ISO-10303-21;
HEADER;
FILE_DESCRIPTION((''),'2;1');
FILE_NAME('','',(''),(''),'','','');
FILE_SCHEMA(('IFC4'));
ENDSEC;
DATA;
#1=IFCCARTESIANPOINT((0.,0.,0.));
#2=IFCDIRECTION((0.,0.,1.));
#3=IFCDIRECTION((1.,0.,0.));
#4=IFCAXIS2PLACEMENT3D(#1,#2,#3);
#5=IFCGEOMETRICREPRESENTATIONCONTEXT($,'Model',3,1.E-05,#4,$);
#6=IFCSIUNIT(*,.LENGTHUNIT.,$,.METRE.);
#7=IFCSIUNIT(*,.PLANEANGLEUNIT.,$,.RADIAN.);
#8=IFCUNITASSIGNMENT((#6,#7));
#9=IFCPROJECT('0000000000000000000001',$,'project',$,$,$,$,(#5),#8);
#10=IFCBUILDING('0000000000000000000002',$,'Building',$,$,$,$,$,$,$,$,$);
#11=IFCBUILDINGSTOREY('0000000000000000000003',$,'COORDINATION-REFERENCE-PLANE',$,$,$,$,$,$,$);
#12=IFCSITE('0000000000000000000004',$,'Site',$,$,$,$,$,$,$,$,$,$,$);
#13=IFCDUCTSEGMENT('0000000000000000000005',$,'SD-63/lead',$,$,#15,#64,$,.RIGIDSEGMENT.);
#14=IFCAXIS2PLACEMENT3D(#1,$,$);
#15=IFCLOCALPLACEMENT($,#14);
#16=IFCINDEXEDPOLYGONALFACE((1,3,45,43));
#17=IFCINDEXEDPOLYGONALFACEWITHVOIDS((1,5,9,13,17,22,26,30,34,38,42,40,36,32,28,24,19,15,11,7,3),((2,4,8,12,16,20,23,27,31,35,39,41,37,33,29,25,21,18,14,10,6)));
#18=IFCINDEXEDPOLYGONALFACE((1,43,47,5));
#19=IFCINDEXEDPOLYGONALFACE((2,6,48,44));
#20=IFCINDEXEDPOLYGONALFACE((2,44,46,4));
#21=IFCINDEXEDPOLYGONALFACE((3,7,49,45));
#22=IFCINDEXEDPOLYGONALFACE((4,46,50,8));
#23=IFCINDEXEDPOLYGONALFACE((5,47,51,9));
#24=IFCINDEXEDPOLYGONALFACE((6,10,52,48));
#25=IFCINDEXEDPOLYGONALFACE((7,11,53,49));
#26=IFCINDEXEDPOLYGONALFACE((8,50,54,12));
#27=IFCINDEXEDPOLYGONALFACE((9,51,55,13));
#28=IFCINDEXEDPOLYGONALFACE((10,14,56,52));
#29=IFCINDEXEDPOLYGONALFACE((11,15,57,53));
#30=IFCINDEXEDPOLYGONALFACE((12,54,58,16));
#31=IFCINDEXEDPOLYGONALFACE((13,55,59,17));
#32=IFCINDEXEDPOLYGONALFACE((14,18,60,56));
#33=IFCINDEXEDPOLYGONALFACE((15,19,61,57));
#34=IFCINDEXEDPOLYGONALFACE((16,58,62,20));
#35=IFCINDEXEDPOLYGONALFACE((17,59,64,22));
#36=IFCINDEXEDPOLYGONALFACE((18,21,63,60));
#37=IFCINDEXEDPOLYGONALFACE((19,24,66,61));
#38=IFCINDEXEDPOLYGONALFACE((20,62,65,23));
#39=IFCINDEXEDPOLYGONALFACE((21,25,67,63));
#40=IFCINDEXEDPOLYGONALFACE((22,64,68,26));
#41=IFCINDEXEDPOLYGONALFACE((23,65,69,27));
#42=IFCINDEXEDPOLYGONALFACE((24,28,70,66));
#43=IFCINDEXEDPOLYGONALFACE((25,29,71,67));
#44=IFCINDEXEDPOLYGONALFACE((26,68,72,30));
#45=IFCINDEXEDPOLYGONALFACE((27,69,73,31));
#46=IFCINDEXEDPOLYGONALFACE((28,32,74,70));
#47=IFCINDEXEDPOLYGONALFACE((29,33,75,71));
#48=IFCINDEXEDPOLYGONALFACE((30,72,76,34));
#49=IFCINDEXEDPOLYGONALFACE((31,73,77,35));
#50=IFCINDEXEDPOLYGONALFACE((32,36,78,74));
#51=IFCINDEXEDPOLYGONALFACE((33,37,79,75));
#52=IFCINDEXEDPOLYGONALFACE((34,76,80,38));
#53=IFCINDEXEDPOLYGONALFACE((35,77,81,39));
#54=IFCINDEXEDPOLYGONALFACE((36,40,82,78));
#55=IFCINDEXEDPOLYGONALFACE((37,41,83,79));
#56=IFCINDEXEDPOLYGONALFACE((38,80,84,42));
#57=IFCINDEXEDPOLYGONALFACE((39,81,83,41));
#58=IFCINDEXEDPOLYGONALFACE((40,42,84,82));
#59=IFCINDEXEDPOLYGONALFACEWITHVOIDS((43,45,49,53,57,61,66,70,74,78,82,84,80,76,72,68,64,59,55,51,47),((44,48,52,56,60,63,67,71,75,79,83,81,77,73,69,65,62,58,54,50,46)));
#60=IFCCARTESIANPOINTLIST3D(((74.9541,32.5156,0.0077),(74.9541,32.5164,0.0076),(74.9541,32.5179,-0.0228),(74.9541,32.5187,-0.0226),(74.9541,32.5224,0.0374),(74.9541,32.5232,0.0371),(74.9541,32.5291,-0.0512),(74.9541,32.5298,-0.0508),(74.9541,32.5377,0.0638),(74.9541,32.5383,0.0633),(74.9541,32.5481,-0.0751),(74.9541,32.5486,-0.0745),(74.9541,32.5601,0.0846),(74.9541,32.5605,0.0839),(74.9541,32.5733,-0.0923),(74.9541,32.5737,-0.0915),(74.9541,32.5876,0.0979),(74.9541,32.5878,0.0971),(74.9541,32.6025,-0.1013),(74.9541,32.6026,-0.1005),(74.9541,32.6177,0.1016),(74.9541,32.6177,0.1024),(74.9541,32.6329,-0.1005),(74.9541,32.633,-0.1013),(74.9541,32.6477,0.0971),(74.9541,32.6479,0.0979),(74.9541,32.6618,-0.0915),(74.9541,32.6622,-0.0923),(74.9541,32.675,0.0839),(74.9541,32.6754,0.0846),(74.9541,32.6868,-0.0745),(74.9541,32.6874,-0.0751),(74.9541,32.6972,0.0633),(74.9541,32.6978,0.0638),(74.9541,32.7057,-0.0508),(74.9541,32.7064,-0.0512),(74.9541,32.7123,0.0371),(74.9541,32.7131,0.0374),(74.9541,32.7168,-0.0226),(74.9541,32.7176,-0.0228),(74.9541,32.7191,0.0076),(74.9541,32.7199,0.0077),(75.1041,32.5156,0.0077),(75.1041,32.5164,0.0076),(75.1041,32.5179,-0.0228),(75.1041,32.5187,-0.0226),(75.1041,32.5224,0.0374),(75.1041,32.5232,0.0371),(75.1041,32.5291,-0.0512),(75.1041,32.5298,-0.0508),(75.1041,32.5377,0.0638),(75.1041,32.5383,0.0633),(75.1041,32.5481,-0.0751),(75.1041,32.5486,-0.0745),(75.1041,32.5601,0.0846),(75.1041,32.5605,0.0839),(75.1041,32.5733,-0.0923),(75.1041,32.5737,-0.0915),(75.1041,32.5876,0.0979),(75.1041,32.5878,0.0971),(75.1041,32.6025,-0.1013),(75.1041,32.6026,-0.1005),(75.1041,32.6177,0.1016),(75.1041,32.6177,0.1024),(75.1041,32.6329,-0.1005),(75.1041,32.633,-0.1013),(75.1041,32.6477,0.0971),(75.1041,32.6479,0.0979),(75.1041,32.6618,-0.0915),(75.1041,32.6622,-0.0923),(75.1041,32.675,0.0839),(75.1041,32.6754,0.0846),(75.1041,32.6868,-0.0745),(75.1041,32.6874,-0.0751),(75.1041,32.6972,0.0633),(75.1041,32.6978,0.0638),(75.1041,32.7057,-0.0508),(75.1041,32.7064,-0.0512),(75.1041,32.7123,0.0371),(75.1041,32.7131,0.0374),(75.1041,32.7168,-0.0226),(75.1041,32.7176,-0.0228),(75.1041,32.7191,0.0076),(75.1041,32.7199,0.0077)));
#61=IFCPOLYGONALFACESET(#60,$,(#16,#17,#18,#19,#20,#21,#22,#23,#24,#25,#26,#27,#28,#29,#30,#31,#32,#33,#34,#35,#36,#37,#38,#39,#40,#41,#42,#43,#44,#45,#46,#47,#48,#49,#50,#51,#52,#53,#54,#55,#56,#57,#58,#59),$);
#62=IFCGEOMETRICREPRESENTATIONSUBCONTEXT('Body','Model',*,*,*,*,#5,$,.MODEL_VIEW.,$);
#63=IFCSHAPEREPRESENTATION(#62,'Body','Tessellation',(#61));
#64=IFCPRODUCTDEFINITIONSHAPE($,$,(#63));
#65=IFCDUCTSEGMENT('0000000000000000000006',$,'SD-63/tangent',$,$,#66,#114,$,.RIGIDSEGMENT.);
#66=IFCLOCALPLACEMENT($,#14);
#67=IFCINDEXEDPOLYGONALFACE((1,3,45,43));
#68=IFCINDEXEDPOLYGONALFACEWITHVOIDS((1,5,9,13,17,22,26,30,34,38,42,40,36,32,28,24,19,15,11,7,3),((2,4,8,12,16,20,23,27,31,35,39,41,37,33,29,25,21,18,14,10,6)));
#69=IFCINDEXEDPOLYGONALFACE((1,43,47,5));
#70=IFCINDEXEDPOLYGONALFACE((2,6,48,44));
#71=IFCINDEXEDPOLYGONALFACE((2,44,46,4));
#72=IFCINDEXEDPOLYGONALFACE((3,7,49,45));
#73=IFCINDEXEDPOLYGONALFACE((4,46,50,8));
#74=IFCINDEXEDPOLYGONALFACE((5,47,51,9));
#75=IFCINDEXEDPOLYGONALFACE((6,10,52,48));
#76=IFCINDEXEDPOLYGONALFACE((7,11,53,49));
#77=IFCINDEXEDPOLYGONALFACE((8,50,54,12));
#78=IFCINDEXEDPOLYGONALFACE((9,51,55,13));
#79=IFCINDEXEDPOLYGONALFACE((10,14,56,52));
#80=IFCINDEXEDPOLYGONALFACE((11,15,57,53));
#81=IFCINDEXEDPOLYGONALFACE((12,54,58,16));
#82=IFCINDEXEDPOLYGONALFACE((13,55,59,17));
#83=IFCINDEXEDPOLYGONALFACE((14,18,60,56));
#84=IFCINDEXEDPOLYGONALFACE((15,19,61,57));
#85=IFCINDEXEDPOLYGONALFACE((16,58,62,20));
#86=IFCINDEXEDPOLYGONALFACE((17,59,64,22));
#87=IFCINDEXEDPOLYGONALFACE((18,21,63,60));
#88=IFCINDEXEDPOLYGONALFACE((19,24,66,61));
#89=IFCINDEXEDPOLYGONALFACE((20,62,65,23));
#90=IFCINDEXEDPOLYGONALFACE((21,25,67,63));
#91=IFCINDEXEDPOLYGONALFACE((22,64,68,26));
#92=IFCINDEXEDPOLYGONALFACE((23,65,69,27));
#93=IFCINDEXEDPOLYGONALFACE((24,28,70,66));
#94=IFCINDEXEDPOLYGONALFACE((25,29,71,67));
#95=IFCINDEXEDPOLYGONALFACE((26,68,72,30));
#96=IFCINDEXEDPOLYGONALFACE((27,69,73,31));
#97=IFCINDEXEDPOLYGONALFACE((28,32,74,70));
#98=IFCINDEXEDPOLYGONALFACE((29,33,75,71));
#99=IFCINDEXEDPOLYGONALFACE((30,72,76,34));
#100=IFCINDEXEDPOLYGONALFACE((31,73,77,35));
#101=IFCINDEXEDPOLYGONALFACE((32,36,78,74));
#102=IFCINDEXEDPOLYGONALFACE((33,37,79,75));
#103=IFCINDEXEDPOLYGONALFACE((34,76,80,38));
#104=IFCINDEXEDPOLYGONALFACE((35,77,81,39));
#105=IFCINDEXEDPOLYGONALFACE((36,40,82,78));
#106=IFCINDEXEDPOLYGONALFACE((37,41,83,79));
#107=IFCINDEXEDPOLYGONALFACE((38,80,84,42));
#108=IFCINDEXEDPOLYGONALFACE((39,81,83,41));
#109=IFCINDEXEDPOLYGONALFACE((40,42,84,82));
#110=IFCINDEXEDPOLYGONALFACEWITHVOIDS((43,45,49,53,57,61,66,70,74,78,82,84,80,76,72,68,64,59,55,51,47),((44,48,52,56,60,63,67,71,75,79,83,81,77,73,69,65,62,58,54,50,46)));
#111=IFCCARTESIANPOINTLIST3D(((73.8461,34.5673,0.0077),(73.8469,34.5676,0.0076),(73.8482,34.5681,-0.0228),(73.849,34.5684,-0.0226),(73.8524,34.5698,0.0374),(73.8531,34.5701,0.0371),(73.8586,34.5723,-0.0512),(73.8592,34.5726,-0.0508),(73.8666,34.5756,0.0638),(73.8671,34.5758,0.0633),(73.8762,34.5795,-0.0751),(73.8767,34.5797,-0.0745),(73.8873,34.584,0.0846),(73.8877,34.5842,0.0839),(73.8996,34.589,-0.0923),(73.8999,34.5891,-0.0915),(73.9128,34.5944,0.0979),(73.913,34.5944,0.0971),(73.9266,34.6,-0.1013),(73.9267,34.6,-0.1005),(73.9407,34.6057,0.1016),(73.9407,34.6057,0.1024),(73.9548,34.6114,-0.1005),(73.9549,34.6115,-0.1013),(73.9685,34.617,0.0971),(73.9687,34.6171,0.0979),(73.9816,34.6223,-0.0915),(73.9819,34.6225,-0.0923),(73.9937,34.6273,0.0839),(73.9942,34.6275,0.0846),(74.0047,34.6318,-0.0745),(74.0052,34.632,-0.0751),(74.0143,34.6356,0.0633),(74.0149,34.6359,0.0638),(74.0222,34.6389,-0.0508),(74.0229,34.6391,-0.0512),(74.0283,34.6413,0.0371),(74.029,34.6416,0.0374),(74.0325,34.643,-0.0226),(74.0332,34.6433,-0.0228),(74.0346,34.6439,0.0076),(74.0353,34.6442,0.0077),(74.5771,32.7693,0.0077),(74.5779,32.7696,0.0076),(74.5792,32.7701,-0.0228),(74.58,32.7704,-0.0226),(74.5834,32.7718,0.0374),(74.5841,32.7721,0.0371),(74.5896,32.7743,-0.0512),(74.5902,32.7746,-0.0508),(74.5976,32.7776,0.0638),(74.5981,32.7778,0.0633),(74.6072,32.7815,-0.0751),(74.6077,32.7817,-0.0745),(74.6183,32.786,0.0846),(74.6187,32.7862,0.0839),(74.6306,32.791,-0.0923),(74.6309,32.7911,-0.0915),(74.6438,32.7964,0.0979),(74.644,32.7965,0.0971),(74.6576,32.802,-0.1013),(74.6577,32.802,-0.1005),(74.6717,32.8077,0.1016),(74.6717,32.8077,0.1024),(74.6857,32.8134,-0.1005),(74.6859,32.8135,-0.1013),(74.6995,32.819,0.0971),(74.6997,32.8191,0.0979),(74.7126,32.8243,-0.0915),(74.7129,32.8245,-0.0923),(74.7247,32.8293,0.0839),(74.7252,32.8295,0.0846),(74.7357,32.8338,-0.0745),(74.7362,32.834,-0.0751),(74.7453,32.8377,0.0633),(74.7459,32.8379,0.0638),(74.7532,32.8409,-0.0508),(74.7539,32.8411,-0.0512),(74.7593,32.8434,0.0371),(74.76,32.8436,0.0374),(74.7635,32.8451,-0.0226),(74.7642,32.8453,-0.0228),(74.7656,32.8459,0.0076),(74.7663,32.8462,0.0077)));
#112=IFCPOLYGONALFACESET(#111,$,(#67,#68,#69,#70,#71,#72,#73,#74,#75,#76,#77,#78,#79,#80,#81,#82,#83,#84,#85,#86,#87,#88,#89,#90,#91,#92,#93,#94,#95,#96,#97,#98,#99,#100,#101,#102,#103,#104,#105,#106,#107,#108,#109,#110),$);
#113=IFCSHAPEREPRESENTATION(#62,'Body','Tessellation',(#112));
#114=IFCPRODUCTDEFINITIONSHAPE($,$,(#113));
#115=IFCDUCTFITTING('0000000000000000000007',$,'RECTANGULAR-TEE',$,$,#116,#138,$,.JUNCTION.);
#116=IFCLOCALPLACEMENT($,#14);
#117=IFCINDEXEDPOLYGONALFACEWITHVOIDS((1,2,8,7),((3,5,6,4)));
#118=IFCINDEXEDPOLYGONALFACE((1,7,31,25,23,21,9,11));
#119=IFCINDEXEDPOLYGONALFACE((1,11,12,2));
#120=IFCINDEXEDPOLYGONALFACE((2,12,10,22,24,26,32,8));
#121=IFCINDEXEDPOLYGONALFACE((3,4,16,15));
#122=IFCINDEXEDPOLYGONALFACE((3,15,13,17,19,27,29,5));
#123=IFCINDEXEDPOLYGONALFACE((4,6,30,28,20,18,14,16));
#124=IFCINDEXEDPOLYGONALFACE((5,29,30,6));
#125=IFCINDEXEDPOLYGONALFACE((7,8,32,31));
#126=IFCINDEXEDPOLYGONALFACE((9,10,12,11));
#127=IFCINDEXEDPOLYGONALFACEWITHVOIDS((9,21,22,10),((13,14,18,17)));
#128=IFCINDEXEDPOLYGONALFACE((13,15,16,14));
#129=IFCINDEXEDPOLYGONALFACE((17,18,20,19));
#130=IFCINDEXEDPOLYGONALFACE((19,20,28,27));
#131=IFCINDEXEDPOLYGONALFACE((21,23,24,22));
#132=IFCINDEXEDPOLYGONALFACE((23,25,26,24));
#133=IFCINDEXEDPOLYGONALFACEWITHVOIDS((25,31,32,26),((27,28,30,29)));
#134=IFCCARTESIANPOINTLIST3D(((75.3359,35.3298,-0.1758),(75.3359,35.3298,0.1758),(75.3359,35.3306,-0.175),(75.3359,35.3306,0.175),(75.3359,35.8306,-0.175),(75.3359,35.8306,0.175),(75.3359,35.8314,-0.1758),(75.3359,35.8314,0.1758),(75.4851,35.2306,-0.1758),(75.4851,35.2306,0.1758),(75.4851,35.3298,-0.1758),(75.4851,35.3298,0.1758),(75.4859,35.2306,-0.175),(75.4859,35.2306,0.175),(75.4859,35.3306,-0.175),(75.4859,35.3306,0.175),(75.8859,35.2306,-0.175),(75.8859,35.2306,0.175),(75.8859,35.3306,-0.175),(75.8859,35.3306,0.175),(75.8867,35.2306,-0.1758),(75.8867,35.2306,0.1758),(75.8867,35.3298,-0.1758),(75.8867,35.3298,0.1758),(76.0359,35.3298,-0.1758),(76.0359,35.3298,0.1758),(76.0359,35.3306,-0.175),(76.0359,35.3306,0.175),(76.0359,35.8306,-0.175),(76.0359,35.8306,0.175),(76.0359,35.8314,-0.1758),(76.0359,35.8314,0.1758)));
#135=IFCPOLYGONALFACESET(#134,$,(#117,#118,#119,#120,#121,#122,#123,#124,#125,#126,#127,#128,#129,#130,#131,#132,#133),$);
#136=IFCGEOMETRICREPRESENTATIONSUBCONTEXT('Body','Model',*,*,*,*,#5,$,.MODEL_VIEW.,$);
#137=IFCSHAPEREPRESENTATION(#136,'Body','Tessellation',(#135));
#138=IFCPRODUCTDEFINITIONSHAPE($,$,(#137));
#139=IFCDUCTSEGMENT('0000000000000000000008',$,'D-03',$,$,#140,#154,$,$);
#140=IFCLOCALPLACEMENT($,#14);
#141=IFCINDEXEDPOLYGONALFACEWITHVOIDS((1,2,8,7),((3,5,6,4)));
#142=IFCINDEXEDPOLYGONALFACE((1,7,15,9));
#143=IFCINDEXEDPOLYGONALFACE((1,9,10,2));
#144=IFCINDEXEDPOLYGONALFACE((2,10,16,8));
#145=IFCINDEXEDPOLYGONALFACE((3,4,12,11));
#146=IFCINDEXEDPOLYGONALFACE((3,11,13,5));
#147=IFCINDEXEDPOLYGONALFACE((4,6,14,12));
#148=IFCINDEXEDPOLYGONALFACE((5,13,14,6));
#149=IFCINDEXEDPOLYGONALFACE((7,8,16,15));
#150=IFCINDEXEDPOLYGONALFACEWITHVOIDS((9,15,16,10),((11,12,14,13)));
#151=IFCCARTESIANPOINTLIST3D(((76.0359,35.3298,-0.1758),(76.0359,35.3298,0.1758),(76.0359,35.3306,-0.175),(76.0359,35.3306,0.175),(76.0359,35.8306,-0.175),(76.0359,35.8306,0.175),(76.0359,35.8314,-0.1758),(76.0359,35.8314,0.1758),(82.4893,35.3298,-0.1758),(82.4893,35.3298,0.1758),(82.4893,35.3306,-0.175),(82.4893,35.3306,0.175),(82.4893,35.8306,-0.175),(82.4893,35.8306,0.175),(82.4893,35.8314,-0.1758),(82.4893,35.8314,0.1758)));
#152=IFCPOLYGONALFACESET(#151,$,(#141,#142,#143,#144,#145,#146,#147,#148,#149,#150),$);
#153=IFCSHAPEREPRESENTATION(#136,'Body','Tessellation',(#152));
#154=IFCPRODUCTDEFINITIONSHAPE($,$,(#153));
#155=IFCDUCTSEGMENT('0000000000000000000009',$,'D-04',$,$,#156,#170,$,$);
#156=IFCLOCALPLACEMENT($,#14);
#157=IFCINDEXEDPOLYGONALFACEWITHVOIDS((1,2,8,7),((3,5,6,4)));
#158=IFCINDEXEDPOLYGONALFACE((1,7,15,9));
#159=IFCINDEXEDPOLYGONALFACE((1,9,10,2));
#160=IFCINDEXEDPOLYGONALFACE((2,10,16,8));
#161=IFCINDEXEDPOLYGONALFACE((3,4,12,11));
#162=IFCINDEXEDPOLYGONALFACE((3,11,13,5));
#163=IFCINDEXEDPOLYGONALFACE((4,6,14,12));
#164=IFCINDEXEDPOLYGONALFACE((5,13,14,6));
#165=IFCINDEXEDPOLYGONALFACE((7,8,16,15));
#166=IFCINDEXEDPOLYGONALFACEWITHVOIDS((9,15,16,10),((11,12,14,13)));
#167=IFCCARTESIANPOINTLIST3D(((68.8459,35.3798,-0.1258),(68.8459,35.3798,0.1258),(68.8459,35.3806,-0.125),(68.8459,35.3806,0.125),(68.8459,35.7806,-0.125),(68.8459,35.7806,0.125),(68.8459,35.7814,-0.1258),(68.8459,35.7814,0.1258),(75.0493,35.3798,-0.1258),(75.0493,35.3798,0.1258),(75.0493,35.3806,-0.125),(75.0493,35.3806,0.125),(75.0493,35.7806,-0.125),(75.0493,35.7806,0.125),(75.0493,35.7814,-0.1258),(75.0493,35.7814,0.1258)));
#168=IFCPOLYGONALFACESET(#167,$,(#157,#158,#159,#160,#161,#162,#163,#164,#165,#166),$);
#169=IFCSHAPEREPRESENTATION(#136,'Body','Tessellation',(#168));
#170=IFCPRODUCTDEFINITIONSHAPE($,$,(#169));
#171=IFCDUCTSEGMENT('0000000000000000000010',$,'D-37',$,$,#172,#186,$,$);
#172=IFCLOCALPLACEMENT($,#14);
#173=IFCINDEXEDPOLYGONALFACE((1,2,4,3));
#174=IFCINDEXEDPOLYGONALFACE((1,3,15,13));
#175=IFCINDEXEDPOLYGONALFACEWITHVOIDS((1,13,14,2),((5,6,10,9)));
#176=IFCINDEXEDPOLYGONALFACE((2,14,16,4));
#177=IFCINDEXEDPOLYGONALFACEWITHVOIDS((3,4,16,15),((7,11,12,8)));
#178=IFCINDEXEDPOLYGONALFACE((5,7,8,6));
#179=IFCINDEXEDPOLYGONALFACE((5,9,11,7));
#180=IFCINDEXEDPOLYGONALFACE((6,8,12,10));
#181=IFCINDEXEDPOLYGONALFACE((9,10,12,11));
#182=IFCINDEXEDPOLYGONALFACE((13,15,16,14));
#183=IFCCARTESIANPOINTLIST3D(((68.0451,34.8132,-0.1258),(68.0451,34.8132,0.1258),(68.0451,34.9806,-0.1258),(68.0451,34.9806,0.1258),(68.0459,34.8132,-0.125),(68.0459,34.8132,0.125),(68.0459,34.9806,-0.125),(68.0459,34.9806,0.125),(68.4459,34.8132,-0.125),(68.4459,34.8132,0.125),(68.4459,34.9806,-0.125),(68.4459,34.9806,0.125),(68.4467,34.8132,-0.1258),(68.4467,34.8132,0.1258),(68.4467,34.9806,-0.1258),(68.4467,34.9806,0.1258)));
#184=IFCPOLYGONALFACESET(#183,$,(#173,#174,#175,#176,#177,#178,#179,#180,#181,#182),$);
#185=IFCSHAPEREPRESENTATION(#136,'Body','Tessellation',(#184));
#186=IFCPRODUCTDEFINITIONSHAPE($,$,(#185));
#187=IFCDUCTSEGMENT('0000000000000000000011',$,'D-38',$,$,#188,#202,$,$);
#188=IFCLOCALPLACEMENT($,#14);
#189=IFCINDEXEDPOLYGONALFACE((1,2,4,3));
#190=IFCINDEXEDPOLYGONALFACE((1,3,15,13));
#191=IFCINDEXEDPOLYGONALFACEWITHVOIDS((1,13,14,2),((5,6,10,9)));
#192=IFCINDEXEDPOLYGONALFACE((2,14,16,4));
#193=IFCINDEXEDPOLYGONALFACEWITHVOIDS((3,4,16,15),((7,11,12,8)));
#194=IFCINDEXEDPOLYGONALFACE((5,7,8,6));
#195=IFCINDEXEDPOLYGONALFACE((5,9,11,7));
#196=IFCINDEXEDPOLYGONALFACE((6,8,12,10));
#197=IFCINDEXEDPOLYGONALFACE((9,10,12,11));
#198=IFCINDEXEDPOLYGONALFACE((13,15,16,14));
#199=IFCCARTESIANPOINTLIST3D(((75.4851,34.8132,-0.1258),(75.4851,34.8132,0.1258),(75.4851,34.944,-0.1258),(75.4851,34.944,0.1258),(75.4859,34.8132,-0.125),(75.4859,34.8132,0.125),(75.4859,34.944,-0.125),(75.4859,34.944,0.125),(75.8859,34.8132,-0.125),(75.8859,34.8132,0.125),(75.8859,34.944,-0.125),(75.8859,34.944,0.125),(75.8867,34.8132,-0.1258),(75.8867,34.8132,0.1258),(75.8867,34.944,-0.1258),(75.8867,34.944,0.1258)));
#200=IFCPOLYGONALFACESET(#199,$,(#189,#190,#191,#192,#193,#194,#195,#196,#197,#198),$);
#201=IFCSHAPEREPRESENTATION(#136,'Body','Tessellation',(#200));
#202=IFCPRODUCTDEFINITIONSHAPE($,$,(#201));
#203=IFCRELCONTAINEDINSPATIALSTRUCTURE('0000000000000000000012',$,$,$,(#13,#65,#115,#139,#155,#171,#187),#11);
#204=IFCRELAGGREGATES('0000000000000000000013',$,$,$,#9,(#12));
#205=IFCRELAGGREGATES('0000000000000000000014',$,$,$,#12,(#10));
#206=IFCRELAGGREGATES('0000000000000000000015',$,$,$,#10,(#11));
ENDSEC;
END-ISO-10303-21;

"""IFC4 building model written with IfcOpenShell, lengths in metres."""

from ifc_helpers import new_model, si_unit, frame, origin, origin_with_axes, place, context, subcontext, project, spatial, rectangle, hollow_rectangle, hollow_circle, extrude, boolean, element, save


model = new_model("IFC4")

# Units and contexts
model_context = context("Model", 3, precision=1e-05, world=origin_with_axes())
body_context_1 = subcontext(model_context, "Body", "Model", "MODEL_VIEW")
body_context_2 = subcontext(model_context, "Body", "Model", "MODEL_VIEW")
ifc_project = project(units=[si_unit("LENGTHUNIT", "METRE"), si_unit("PLANEANGLEUNIT", "RADIAN")], contexts=[model_context])

# Site, building, storey
site = spatial("IfcSite", under=ifc_project, Name="Site")
building = spatial("IfcBuilding", under=site, Name="Building")
storey = spatial("IfcBuildingStorey", under=building, Name="COORDINATION-REFERENCE-PLANE")

# Duct segment
for number, where, z_axis, x_axis, name in (
    (1, (75.1041, 32.6177, 0.0), (-1.0, 0.0, 0.0), (0.0, 0.0, 1.0), "SD-63/lead"),
):
    element("IfcDuctSegment", number, at=place(None, frame(where, z_axis=z_axis, x_axis=x_axis)), inside=storey, Name=name, PredefinedType="RIGIDSEGMENT", context=body_context_1, shape_type="SweptSolid", body=[
        extrude(hollow_circle(Radius=0.1024, WallThickness=0.0008), origin_with_axes(), (0.0, 0.0, 1.0), 0.15),
    ])

# Duct segment
duct_segment_1_placement = place(None, frame((74.6717, 32.8077, 0.0), z_axis=(-0.376625, 0.926366, 0.0), x_axis=(0.0, 0.0, 1.0)))
element("IfcDuctSegment", 2, at=duct_segment_1_placement, inside=storey, Name="SD-63/tangent", PredefinedType="RIGIDSEGMENT", context=body_context_1, shape_type="SweptSolid", body=[
    extrude(hollow_circle(Radius=0.1024, WallThickness=0.0008), origin_with_axes(), (0.0, 0.0, 1.0), 1.9409),
])

# Duct fitting
duct_fitting_1_placement = place(None, frame((75.6859, 35.5806, 0.0), z_axis=(-1.0, 0.0, 0.0), x_axis=(0.0, -1.0, 0.0)))
solid = boolean("UNION", extrude(rectangle(XDim=0.5, YDim=0.35), frame((0.0, 0.0, -0.35), z_axis=(0.0, 0.0, 1.0), x_axis=(1.0, 0.0, 0.0)), (0.0, 0.0, 1.0), 0.7), extrude(rectangle(XDim=0.4, YDim=0.35), frame((0.0, 0.0, 0.0), z_axis=(1.0, 0.0, 0.0), x_axis=(0.0, 0.0, -1.0)), (0.0, 0.0, 1.0), 0.35))
element("IfcDuctFitting", 3, at=duct_fitting_1_placement, inside=storey, Name="RECTANGULAR-TEE", PredefinedType="JUNCTION", context=body_context_2, shape_type="CSG", body=[
    boolean("DIFFERENCE", boolean("UNION", extrude(rectangle(XDim=0.5016, YDim=0.3516), frame((0.0, 0.0, -0.35), z_axis=(0.0, 0.0, 1.0), x_axis=(1.0, 0.0, 0.0)), (0.0, 0.0, 1.0), 0.7), extrude(rectangle(XDim=0.4016, YDim=0.3516), frame((0.0, 0.0, 0.0), z_axis=(1.0, 0.0, 0.0), x_axis=(0.0, 0.0, -1.0)), (0.0, 0.0, 1.0), 0.35)), solid),
])

# Duct segments
duct_segment_2_placement = place(None, frame((76.0359, 35.5806, 0.0), z_axis=(1.0, 0.0, 0.0), x_axis=(0.0, 1.0, 0.0)))
element("IfcDuctSegment", 4, at=duct_segment_2_placement, inside=storey, Name="D-03", context=body_context_2, shape_type="SweptSolid", body=[
    extrude(hollow_rectangle(XDim=0.5016, YDim=0.3516, WallThickness=0.0008), origin(), (0.0, 0.0, 1.0), 6.4534),
])
duct_segment_3_placement = place(None, frame((68.8459, 35.5806, 0.0), z_axis=(1.0, 0.0, 0.0), x_axis=(0.0, 1.0, 0.0)))
element("IfcDuctSegment", 5, at=duct_segment_3_placement, inside=storey, Name="D-04", context=body_context_2, shape_type="SweptSolid", body=[
    extrude(hollow_rectangle(XDim=0.4016, YDim=0.2516, WallThickness=0.0008), origin(), (0.0, 0.0, 1.0), 6.2034),
])
duct_segment_4_placement = place(None, frame((68.2459, 34.8132, 0.0), z_axis=(0.0, 1.0, 0.0), x_axis=(1.0, 0.0, 0.0)))
element("IfcDuctSegment", 6, at=duct_segment_4_placement, inside=storey, Name="D-37", context=body_context_2, shape_type="SweptSolid", body=[
    extrude(hollow_rectangle(XDim=0.4016, YDim=0.2516, WallThickness=0.0008), origin(), (0.0, 0.0, 1.0), 0.1673),
])
duct_segment_5_placement = place(None, frame((75.6859, 34.8132, 0.0), z_axis=(0.0, 1.0, 0.0), x_axis=(1.0, 0.0, 0.0)))
element("IfcDuctSegment", 7, at=duct_segment_5_placement, inside=storey, Name="D-38", context=body_context_2, shape_type="SweptSolid", body=[
    extrude(hollow_rectangle(XDim=0.4016, YDim=0.2516, WallThickness=0.0008), origin(), (0.0, 0.0, 1.0), 0.1307),
])

save(model, "model.ifc")
